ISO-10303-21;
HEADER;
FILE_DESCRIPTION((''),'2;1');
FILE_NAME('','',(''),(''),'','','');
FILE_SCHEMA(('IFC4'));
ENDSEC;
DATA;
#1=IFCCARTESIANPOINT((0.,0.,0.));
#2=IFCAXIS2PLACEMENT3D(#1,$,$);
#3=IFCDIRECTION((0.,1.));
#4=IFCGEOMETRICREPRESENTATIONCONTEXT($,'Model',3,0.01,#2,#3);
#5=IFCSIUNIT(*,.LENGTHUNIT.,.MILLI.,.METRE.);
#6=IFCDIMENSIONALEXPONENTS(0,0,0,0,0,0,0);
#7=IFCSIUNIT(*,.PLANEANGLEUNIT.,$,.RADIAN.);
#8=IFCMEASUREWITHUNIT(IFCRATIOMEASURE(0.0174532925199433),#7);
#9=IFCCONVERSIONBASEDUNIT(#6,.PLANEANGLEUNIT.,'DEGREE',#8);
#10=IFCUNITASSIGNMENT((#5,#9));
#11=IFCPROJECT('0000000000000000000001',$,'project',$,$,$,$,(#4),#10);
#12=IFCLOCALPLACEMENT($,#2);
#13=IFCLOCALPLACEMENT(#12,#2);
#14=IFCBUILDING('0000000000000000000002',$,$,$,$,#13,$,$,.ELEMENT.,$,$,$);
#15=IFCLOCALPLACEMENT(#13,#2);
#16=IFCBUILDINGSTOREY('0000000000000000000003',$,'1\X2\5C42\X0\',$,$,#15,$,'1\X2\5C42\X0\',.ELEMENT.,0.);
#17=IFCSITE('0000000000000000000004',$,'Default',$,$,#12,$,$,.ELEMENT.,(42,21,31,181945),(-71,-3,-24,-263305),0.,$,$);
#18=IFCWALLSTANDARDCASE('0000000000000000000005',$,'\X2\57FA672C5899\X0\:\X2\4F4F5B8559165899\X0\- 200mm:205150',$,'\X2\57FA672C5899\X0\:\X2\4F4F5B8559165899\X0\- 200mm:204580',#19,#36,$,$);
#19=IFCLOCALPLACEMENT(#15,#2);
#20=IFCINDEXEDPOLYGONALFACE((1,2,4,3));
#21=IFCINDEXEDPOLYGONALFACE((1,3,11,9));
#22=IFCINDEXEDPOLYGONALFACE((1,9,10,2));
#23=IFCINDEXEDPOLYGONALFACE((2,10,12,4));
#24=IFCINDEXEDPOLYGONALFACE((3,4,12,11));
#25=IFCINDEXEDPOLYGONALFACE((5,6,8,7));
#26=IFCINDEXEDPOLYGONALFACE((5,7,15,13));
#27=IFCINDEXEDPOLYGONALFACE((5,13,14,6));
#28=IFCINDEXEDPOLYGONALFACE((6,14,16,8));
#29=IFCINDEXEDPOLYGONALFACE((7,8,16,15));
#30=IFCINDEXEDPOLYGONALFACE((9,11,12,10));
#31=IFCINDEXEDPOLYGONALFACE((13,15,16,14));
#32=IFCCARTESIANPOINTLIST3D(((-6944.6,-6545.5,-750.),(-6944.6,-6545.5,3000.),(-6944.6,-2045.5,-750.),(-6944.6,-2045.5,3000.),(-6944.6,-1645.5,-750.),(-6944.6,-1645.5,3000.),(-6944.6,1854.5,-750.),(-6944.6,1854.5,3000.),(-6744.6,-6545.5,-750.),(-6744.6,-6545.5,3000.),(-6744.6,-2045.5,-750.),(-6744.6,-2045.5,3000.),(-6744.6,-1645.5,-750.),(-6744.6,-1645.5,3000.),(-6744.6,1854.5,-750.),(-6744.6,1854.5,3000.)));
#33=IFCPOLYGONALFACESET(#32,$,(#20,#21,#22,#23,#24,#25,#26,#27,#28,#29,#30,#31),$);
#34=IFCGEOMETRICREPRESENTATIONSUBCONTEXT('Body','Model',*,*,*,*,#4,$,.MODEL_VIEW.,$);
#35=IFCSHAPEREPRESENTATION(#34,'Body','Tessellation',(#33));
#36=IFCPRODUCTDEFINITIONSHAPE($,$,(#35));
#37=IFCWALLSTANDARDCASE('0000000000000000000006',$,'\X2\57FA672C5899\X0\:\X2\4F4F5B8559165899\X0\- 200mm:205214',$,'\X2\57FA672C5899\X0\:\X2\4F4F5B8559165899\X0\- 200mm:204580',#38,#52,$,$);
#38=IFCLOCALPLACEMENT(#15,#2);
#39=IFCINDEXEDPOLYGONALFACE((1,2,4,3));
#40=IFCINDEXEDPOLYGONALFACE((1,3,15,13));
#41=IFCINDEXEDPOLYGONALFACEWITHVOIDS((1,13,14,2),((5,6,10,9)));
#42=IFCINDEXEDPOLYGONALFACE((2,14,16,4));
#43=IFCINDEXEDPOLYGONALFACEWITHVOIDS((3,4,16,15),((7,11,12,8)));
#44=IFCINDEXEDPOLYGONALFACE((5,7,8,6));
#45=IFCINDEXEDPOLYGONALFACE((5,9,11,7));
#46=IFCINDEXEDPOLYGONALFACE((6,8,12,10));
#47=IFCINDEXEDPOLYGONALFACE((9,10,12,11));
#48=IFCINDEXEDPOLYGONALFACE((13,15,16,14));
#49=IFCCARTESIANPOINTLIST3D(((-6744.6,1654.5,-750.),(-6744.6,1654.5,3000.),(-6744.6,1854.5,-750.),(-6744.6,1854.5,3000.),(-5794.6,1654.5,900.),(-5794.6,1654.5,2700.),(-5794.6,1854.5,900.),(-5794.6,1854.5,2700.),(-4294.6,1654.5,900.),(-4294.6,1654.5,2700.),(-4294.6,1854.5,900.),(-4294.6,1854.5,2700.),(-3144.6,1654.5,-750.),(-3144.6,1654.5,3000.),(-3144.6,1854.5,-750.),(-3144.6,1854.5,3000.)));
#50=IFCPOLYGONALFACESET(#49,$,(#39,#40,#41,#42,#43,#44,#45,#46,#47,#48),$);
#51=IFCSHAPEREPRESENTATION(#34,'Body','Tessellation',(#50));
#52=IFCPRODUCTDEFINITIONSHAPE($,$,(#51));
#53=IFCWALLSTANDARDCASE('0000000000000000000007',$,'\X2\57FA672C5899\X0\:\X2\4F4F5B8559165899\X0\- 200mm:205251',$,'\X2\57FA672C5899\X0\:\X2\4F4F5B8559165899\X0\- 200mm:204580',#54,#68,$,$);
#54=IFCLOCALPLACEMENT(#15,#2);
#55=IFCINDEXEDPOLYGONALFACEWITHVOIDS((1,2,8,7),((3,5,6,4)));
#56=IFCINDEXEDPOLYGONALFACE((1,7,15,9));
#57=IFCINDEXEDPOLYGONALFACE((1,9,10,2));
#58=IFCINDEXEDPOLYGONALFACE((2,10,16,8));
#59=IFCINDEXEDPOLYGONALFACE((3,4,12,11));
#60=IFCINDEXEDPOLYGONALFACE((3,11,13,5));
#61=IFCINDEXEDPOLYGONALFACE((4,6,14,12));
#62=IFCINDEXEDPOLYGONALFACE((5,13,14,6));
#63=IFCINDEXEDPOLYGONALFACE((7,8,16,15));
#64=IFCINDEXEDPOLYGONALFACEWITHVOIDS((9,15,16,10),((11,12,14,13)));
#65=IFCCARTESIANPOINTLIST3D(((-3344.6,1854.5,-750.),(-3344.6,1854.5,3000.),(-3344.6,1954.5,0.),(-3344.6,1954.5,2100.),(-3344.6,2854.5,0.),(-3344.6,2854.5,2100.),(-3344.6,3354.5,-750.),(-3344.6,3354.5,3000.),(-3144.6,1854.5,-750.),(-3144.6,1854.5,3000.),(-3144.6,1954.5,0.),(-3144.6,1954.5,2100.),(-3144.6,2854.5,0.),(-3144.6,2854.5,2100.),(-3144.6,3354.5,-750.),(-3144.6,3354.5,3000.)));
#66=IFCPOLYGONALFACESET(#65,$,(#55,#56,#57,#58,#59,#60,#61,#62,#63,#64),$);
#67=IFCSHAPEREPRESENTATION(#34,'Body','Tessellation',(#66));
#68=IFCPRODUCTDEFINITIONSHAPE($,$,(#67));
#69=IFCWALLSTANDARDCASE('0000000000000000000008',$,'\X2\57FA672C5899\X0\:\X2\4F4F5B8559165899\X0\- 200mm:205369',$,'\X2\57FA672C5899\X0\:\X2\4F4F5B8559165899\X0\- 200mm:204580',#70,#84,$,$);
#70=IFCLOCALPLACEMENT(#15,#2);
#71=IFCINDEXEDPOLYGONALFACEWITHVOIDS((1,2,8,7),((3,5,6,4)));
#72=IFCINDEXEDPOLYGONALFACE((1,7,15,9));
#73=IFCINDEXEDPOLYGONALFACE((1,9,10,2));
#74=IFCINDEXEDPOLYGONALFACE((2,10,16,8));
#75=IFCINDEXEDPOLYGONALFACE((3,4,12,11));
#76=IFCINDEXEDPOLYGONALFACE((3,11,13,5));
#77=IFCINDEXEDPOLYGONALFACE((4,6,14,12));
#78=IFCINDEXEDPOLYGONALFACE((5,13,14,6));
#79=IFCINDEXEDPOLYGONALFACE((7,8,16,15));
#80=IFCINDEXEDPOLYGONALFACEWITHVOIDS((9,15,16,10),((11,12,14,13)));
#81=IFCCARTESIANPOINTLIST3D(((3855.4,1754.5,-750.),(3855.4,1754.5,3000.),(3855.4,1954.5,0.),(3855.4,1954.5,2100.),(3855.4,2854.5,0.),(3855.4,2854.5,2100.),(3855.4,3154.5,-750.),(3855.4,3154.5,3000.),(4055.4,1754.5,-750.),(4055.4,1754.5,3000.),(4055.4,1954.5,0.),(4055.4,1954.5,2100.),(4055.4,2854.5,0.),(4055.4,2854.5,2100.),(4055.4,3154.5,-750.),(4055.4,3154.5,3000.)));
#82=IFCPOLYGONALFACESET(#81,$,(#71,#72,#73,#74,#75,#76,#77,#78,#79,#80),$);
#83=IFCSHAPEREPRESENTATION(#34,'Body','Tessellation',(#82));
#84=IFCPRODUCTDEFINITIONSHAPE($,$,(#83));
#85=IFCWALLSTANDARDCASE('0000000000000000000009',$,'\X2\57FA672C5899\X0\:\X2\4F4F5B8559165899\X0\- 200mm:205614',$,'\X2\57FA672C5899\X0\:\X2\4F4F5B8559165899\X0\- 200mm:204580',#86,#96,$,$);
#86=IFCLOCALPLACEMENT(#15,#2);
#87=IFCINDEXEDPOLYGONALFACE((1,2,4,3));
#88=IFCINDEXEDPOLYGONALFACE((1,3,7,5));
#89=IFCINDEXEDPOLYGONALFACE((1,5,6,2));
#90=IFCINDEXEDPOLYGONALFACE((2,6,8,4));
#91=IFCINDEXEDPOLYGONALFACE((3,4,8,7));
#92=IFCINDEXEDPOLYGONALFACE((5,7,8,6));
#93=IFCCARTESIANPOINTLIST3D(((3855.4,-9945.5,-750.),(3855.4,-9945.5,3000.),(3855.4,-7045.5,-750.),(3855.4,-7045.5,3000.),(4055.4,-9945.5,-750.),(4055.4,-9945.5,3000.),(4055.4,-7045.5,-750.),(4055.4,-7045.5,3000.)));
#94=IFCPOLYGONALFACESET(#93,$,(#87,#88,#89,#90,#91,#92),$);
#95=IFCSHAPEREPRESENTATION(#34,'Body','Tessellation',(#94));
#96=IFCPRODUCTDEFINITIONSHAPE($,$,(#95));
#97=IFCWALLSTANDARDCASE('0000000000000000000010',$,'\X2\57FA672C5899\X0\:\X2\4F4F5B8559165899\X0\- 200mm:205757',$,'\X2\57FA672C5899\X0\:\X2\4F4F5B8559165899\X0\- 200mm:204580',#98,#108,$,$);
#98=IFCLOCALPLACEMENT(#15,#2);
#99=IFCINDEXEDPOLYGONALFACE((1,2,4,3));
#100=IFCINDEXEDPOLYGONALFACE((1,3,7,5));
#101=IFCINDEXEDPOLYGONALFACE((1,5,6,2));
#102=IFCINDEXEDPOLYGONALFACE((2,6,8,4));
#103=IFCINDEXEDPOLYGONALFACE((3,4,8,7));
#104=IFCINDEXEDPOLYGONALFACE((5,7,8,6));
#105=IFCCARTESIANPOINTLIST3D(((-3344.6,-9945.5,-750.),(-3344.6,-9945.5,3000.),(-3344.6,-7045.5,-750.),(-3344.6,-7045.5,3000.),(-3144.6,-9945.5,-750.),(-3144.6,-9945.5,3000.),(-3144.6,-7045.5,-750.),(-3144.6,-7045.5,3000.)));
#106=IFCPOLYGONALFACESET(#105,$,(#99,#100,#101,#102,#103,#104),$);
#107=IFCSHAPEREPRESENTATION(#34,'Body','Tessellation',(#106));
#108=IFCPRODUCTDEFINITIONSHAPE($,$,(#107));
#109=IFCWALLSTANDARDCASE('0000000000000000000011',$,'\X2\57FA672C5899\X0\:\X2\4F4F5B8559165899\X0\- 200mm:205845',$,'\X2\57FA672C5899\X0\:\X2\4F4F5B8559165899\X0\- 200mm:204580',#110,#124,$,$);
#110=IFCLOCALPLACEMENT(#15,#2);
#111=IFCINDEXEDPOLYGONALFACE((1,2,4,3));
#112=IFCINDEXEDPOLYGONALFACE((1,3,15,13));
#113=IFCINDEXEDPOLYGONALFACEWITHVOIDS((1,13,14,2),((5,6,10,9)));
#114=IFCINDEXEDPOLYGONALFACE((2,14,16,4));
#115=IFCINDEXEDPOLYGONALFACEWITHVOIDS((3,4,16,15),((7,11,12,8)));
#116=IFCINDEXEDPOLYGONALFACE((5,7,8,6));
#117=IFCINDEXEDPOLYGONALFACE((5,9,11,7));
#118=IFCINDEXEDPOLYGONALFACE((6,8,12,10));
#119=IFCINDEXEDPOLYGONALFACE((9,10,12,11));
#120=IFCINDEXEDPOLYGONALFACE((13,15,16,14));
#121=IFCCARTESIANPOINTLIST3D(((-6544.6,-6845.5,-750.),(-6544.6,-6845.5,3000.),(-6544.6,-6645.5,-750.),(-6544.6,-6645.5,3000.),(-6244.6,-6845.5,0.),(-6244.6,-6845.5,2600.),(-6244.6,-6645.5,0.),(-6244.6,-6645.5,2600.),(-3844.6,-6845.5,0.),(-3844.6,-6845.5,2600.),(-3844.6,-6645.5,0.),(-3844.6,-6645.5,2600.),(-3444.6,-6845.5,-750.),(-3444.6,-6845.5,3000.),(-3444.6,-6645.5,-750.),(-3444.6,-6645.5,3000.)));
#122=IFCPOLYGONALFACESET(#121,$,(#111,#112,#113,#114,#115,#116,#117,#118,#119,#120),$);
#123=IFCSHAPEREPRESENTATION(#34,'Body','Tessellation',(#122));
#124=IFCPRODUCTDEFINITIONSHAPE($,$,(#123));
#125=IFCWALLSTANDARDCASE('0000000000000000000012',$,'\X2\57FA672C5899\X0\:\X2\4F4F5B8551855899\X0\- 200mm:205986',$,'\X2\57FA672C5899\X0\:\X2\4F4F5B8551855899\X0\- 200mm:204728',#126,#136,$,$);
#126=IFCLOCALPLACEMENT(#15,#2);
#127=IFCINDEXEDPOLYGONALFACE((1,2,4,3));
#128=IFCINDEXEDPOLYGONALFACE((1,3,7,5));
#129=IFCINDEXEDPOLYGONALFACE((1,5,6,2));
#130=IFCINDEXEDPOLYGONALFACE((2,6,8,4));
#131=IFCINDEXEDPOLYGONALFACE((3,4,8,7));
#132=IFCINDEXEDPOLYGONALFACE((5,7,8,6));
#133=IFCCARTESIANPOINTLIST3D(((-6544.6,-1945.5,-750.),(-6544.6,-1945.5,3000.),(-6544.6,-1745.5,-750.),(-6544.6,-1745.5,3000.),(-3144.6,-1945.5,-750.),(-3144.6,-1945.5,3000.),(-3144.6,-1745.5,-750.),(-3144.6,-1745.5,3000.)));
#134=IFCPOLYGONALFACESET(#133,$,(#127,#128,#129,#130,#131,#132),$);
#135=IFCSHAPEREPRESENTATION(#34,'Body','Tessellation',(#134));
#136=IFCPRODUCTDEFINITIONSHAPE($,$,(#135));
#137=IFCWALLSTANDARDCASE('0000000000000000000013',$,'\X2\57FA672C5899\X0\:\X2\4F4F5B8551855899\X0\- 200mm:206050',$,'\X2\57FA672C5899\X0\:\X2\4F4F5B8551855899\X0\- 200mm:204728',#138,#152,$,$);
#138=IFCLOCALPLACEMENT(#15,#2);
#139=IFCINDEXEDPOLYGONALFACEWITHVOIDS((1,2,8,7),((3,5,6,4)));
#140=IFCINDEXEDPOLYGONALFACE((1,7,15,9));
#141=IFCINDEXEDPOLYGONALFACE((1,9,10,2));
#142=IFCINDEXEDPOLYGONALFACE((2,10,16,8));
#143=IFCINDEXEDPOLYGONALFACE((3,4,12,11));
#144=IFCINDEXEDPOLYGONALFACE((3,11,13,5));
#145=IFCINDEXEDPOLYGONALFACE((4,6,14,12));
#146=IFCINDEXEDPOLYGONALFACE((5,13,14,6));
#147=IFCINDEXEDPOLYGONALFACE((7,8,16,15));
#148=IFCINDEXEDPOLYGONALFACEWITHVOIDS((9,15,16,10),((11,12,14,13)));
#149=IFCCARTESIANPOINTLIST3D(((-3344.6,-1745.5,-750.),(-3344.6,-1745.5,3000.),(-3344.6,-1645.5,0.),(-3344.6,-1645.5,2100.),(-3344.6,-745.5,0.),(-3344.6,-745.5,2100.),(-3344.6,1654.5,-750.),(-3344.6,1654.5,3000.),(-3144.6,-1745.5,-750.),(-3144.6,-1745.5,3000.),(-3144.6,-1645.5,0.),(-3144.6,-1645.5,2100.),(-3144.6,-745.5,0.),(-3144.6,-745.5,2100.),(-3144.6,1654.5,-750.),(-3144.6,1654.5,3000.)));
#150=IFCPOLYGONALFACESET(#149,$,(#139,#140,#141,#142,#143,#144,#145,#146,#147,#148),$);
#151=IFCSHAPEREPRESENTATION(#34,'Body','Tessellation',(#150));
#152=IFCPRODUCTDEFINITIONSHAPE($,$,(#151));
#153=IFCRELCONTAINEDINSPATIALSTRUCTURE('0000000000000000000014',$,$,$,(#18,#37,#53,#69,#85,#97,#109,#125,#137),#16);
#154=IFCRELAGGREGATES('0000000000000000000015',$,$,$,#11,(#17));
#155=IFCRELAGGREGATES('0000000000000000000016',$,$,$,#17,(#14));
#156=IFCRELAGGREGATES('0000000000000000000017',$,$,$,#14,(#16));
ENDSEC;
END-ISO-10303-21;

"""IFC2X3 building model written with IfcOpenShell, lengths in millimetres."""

from ifc_helpers import new_model, entity, si_unit, converted_unit, direction, frame, frame_2d, origin, origin_2d_with_axis, place, context, subcontext, project, spatial, polyline, rectangle, extrude, clip, bounded_halfspace, element, save


model = new_model("IFC2X3")

# Units and contexts
model_context = context("Model", 3, precision=0.01, world=origin(), true_north=direction((0.0, 1.0)))
body_context = subcontext(model_context, "Body", "Model", "MODEL_VIEW")
ifc_project = project(units=[si_unit("LENGTHUNIT", "METRE", prefix="MILLI"), converted_unit("PLANEANGLEUNIT", "DEGREE", entity("IfcRatioMeasure", 0.0174532925199433), si_unit("PLANEANGLEUNIT", "RADIAN"), dimensions=[0, 0, 0, 0, 0, 0, 0])], contexts=[model_context])

# Site, building, storey
site_placement = place(None, origin())
site = spatial("IfcSite", under=ifc_project, at=site_placement, Name="Default", CompositionType="ELEMENT", RefLatitude=(42, 21, 31, 181945), RefLongitude=(-71, -3, -24, -263305), RefElevation=0.0)
building_placement = place(site_placement, origin())
building = spatial("IfcBuilding", under=site, at=building_placement, CompositionType="ELEMENT")
storey_placement = place(building_placement, origin())
storey = spatial("IfcBuildingStorey", under=building, at=storey_placement, Name="1层", LongName="1层", CompositionType="ELEMENT", Elevation=0.0)

# Walls, openings
wall_1_placement = place(storey_placement, frame((-6844.6, -6545.5, -750.0), z_axis=(0.0, 0.0, 1.0), x_axis=(0.0, 1.0, 0.0)))
wall_1 = element("IfcWallStandardCase", 1, at=wall_1_placement, inside=storey, Name="基本墙:住宅外墙- 200mm:205150", ObjectType="基本墙:住宅外墙- 200mm:204580", context=body_context, shape_type="Clipping", body=[
    clip(extrude(rectangle(XDim=8400.0, YDim=200.0, at=frame_2d((4200.0, 0.0), x_axis=(-1.0, 0.0))), origin(), (0.0, 0.0, 1.0), 3750.0), bounded_halfspace(frame((0.0, -100.0, 0.0), z_axis=(1.0, 0.0, 0.0), x_axis=(0.0, 0.0, -1.0)), True, frame((0.0, -100.0, 0.0), z_axis=(1.0, 0.0, 0.0), x_axis=(0.0, 0.0, -1.0)), polyline([(0.0, 0.0), (0.0, 200.0), (-3750.0, 200.0), (-3750.0, 0.0), (0.0, 0.0)]))),
])
opening_1_placement = place(storey_placement, frame((-6844.6, -6545.5, -750.0), z_axis=(0.0, 0.0, 1.0), x_axis=(0.0, 1.0, 0.0)))
element("IfcOpeningElement", 2, at=opening_1_placement, cuts=wall_1, ObjectType="Opening", context=body_context, shape_type="SweptSolid", body=[
    extrude(rectangle(XDim=3750.0, YDim=200.0, at=origin_2d_with_axis()), frame((4500.0, 0.0, 1875.0), z_axis=(1.0, 0.0, 0.0), x_axis=(0.0, 0.0, -1.0)), (0.0, 0.0, 1.0), 400.0),
])
wall_2_placement = place(storey_placement, frame((-6744.6, 1754.5, -750.0)))
wall_2 = element("IfcWallStandardCase", 3, at=wall_2_placement, inside=storey, Name="基本墙:住宅外墙- 200mm:205214", ObjectType="基本墙:住宅外墙- 200mm:204580", context=body_context, shape_type="SweptSolid", body=[
    extrude(rectangle(XDim=3600.0, YDim=200.0, at=frame_2d((1800.0, 0.0), x_axis=(-1.0, 0.0))), origin(), (0.0, 0.0, 1.0), 3750.0),
])
opening_2_placement = place(wall_2_placement, frame((950.0, -100.0, 1650.0)))
element("IfcOpeningElement", 4, at=opening_2_placement, cuts=wall_2, ObjectType="Opening", context=body_context, shape_type="SweptSolid", body=[
    extrude(rectangle(XDim=1800.0, YDim=1500.0, at=frame_2d((900.0, 750.0), x_axis=(1.0, 0.0))), frame((0.0, 0.0, 0.0), z_axis=(0.0, 1.0, 0.0), x_axis=(0.0, 0.0, 1.0)), (0.0, 0.0, 1.0), 200.0),
])

# Walls, openings
wall_3_placement = place(storey_placement, frame((-3244.6, 1854.5, -750.0), z_axis=(0.0, 0.0, 1.0), x_axis=(0.0, 1.0, 0.0)))
wall_3 = element("IfcWallStandardCase", 5, at=wall_3_placement, inside=storey, Name="基本墙:住宅外墙- 200mm:205251", ObjectType="基本墙:住宅外墙- 200mm:204580", context=body_context, shape_type="SweptSolid", body=[
    extrude(rectangle(XDim=1500.0, YDim=200.0, at=frame_2d((750.0, 0.0), x_axis=(-1.0, 0.0))), origin(), (0.0, 0.0, 1.0), 3750.0),
])
opening_3_placement = place(wall_3_placement, frame((100.0, -100.0, 750.0)))
element("IfcOpeningElement", 6, at=opening_3_placement, cuts=wall_3, ObjectType="Opening", context=body_context, shape_type="SweptSolid", body=[
    extrude(rectangle(XDim=2100.0, YDim=900.0, at=frame_2d((1050.0, 450.0), x_axis=(1.0, 0.0))), frame((0.0, 0.0, 0.0), z_axis=(0.0, 1.0, 0.0), x_axis=(0.0, 0.0, 1.0)), (0.0, 0.0, 1.0), 200.0),
])
opening_4_placement = place(wall_3_placement, origin())
element("IfcOpeningElement", 7, at=opening_4_placement, cuts=wall_3, ObjectType="Opening", context=body_context, shape_type="SweptSolid", body=[
    extrude(rectangle(XDim=2100.0, YDim=900.0, at=frame_2d((0.0, 0.0), x_axis=(1.0, 0.0))), frame((550.0, -1624.0, 4800.0), z_axis=(0.0, 1.0, 0.0), x_axis=(0.0, 0.0, 1.0)), (0.0, 0.0, 1.0), 3048.0),
])
wall_4_placement = place(storey_placement, frame((3955.4, 3154.5, -750.0), z_axis=(0.0, 0.0, 1.0), x_axis=(0.0, -1.0, 0.0)))
wall_4 = element("IfcWallStandardCase", 8, at=wall_4_placement, inside=storey, Name="基本墙:住宅外墙- 200mm:205369", ObjectType="基本墙:住宅外墙- 200mm:204580", context=body_context, shape_type="SweptSolid", body=[
    extrude(rectangle(XDim=1400.0, YDim=200.0, at=frame_2d((700.0, 0.0), x_axis=(-1.0, 0.0))), origin(), (0.0, 0.0, 1.0), 3750.0),
])
opening_5_placement = place(wall_4_placement, frame((300.0, -100.0, 750.0)))
element("IfcOpeningElement", 9, at=opening_5_placement, cuts=wall_4, ObjectType="Opening", context=body_context, shape_type="SweptSolid", body=[
    extrude(rectangle(XDim=2100.0, YDim=900.0, at=frame_2d((1050.0, 450.0), x_axis=(1.0, 0.0))), frame((0.0, 0.0, 0.0), z_axis=(0.0, 1.0, 0.0), x_axis=(0.0, 0.0, 1.0)), (0.0, 0.0, 1.0), 200.0),
])
opening_6_placement = place(wall_4_placement, origin())
element("IfcOpeningElement", 10, at=opening_6_placement, cuts=wall_4, ObjectType="Opening", context=body_context, shape_type="SweptSolid", body=[
    extrude(rectangle(XDim=2100.0, YDim=900.0, at=frame_2d((0.0, 0.0), x_axis=(0.0, 1.0))), frame((750.0, -1624.0, 4800.0), z_axis=(0.0, 1.0, 0.0), x_axis=(-1.0, 0.0, 0.0)), (0.0, 0.0, 1.0), 3048.0),
])

# Walls
wall_5_placement = place(storey_placement, frame((3955.4, -7045.5, -750.0), z_axis=(0.0, 0.0, 1.0), x_axis=(0.0, -1.0, 0.0)))
element("IfcWallStandardCase", 11, at=wall_5_placement, inside=storey, Name="基本墙:住宅外墙- 200mm:205614", ObjectType="基本墙:住宅外墙- 200mm:204580", context=body_context, shape_type="Clipping", body=[
    clip(clip(extrude(rectangle(XDim=2900.0, YDim=200.0, at=frame_2d((1450.0, 0.0), x_axis=(-1.0, 0.0))), origin(), (0.0, 0.0, 1.0), 3750.0), bounded_halfspace(frame((0.0, -100.0, 0.0), z_axis=(-1.0, 0.0, 0.0), x_axis=(0.0, 0.0, -1.0)), False, frame((0.0, -100.0, 0.0), z_axis=(-1.0, 0.0, 0.0), x_axis=(0.0, 0.0, -1.0)), polyline([(0.0, 0.0), (-3750.0, 0.0), (-3750.0, -200.0), (0.0, -200.0), (0.0, 0.0)]))), bounded_halfspace(frame((2900.0, -100.0, 3750.0), z_axis=(1.0, 0.0, 0.0), x_axis=(0.0, 0.0, -1.0)), False, frame((2900.0, -100.0, 3750.0), z_axis=(1.0, 0.0, 0.0), x_axis=(0.0, 0.0, -1.0)), polyline([(0.0, 0.0), (3750.0, 0.0), (3750.0, 200.0), (0.0, 200.0), (0.0, 0.0)]))),
])
wall_6_placement = place(storey_placement, frame((-3244.6, -9945.5, -750.0), z_axis=(0.0, 0.0, 1.0), x_axis=(0.0, 1.0, 0.0)))
element("IfcWallStandardCase", 12, at=wall_6_placement, inside=storey, Name="基本墙:住宅外墙- 200mm:205757", ObjectType="基本墙:住宅外墙- 200mm:204580", context=body_context, shape_type="Clipping", body=[
    clip(clip(extrude(rectangle(XDim=2900.0, YDim=200.0, at=frame_2d((1450.0, 0.0), x_axis=(-1.0, 0.0))), origin(), (0.0, 0.0, 1.0), 3750.0), bounded_halfspace(frame((0.0, -100.0, 0.0), z_axis=(1.0, 0.0, 0.0), x_axis=(0.0, 0.0, -1.0)), True, frame((0.0, -100.0, 0.0), z_axis=(1.0, 0.0, 0.0), x_axis=(0.0, 0.0, -1.0)), polyline([(0.0, 0.0), (0.0, 200.0), (-3750.0, 200.0), (-3750.0, 0.0), (-750.0, 0.0), (-630.0, 0.0), (0.0, 0.0)]))), bounded_halfspace(frame((2900.0, -100.0, 3750.0), z_axis=(-1.0, 0.0, 0.0), x_axis=(0.0, 0.0, -1.0)), True, frame((2900.0, -100.0, 3750.0), z_axis=(-1.0, 0.0, 0.0), x_axis=(0.0, 0.0, -1.0)), polyline([(0.0, 0.0), (0.0, -200.0), (3750.0, -200.0), (3750.0, 0.0), (0.0, 0.0)]))),
])

# Wall, opening
wall_7_placement = place(storey_placement, frame((-3444.6, -6745.5, -750.0), z_axis=(0.0, 0.0, 1.0), x_axis=(-1.0, 0.0, 0.0)))
wall_7 = element("IfcWallStandardCase", 13, at=wall_7_placement, inside=storey, Name="基本墙:住宅外墙- 200mm:205845", ObjectType="基本墙:住宅外墙- 200mm:204580", context=body_context, shape_type="Clipping", body=[
    clip(clip(extrude(rectangle(XDim=3100.0, YDim=200.0, at=frame_2d((1550.0, 0.0), x_axis=(-1.0, 0.0))), origin(), (0.0, 0.0, 1.0), 3750.0), bounded_halfspace(frame((0.0, -100.0, 0.0), z_axis=(1.0, 0.0, 0.0), x_axis=(0.0, 0.0, -1.0)), True, frame((0.0, -100.0, 0.0), z_axis=(1.0, 0.0, 0.0), x_axis=(0.0, 0.0, -1.0)), polyline([(0.0, 0.0), (0.0, 200.0), (-3750.0, 200.0), (-3750.0, 0.0), (0.0, 0.0)]))), bounded_halfspace(frame((3100.0, -100.0, 3750.0), z_axis=(-1.0, 0.0, 0.0), x_axis=(0.0, 0.0, -1.0)), True, frame((3100.0, -100.0, 3750.0), z_axis=(-1.0, 0.0, 0.0), x_axis=(0.0, 0.0, -1.0)), polyline([(0.0, 0.0), (0.0, -200.0), (3750.0, -200.0), (3750.0, 0.0), (0.0, 0.0)]))),
])
opening_7_placement = place(wall_7_placement, frame((400.0, -100.0, 750.0)))
element("IfcOpeningElement", 14, at=opening_7_placement, cuts=wall_7, ObjectType="Opening", context=body_context, shape_type="SweptSolid", body=[
    extrude(rectangle(XDim=2600.0, YDim=2400.0, at=frame_2d((1300.0, 1200.0), x_axis=(1.0, 0.0))), frame((0.0, 0.0, 0.0), z_axis=(0.0, 1.0, 0.0), x_axis=(0.0, 0.0, 1.0)), (0.0, 0.0, 1.0), 200.0),
])

# Wall
wall_8_placement = place(storey_placement, frame((-6544.6, -1845.5, -750.0)))
element("IfcWallStandardCase", 15, at=wall_8_placement, inside=storey, Name="基本墙:住宅内墙- 200mm:205986", ObjectType="基本墙:住宅内墙- 200mm:204728", context=body_context, shape_type="Clipping", body=[
    clip(extrude(rectangle(XDim=3400.0, YDim=200.0, at=frame_2d((1700.0, 0.0), x_axis=(-1.0, 0.0))), origin(), (0.0, 0.0, 1.0), 3750.0), bounded_halfspace(frame((0.0, -100.0, 0.0), z_axis=(1.0, 0.0, 0.0), x_axis=(0.0, 0.0, -1.0)), True, frame((0.0, -100.0, 0.0), z_axis=(1.0, 0.0, 0.0), x_axis=(0.0, 0.0, -1.0)), polyline([(0.0, 0.0), (0.0, 200.0), (-3750.0, 200.0), (-3750.0, 0.0), (0.0, 0.0)]))),
])

# Wall, opening
wall_9_placement = place(storey_placement, frame((-3244.6, -1745.5, -750.0), z_axis=(0.0, 0.0, 1.0), x_axis=(0.0, 1.0, 0.0)))
wall_9 = element("IfcWallStandardCase", 16, at=wall_9_placement, inside=storey, Name="基本墙:住宅内墙- 200mm:206050", ObjectType="基本墙:住宅内墙- 200mm:204728", context=body_context, shape_type="SweptSolid", body=[
    extrude(rectangle(XDim=3400.0, YDim=200.0, at=frame_2d((1700.0, 0.0), x_axis=(-1.0, 0.0))), origin(), (0.0, 0.0, 1.0), 3750.0),
])
opening_8_placement = place(wall_9_placement, frame((100.0, -100.0, 750.0)))
element("IfcOpeningElement", 17, at=opening_8_placement, cuts=wall_9, ObjectType="Opening", context=body_context, shape_type="SweptSolid", body=[
    extrude(rectangle(XDim=2100.0, YDim=900.0, at=frame_2d((1050.0, 450.0), x_axis=(1.0, 0.0))), frame((0.0, 0.0, 0.0), z_axis=(0.0, 1.0, 0.0), x_axis=(0.0, 0.0, 1.0)), (0.0, 0.0, 1.0), 200.0),
])

save(model, "model.ifc")
